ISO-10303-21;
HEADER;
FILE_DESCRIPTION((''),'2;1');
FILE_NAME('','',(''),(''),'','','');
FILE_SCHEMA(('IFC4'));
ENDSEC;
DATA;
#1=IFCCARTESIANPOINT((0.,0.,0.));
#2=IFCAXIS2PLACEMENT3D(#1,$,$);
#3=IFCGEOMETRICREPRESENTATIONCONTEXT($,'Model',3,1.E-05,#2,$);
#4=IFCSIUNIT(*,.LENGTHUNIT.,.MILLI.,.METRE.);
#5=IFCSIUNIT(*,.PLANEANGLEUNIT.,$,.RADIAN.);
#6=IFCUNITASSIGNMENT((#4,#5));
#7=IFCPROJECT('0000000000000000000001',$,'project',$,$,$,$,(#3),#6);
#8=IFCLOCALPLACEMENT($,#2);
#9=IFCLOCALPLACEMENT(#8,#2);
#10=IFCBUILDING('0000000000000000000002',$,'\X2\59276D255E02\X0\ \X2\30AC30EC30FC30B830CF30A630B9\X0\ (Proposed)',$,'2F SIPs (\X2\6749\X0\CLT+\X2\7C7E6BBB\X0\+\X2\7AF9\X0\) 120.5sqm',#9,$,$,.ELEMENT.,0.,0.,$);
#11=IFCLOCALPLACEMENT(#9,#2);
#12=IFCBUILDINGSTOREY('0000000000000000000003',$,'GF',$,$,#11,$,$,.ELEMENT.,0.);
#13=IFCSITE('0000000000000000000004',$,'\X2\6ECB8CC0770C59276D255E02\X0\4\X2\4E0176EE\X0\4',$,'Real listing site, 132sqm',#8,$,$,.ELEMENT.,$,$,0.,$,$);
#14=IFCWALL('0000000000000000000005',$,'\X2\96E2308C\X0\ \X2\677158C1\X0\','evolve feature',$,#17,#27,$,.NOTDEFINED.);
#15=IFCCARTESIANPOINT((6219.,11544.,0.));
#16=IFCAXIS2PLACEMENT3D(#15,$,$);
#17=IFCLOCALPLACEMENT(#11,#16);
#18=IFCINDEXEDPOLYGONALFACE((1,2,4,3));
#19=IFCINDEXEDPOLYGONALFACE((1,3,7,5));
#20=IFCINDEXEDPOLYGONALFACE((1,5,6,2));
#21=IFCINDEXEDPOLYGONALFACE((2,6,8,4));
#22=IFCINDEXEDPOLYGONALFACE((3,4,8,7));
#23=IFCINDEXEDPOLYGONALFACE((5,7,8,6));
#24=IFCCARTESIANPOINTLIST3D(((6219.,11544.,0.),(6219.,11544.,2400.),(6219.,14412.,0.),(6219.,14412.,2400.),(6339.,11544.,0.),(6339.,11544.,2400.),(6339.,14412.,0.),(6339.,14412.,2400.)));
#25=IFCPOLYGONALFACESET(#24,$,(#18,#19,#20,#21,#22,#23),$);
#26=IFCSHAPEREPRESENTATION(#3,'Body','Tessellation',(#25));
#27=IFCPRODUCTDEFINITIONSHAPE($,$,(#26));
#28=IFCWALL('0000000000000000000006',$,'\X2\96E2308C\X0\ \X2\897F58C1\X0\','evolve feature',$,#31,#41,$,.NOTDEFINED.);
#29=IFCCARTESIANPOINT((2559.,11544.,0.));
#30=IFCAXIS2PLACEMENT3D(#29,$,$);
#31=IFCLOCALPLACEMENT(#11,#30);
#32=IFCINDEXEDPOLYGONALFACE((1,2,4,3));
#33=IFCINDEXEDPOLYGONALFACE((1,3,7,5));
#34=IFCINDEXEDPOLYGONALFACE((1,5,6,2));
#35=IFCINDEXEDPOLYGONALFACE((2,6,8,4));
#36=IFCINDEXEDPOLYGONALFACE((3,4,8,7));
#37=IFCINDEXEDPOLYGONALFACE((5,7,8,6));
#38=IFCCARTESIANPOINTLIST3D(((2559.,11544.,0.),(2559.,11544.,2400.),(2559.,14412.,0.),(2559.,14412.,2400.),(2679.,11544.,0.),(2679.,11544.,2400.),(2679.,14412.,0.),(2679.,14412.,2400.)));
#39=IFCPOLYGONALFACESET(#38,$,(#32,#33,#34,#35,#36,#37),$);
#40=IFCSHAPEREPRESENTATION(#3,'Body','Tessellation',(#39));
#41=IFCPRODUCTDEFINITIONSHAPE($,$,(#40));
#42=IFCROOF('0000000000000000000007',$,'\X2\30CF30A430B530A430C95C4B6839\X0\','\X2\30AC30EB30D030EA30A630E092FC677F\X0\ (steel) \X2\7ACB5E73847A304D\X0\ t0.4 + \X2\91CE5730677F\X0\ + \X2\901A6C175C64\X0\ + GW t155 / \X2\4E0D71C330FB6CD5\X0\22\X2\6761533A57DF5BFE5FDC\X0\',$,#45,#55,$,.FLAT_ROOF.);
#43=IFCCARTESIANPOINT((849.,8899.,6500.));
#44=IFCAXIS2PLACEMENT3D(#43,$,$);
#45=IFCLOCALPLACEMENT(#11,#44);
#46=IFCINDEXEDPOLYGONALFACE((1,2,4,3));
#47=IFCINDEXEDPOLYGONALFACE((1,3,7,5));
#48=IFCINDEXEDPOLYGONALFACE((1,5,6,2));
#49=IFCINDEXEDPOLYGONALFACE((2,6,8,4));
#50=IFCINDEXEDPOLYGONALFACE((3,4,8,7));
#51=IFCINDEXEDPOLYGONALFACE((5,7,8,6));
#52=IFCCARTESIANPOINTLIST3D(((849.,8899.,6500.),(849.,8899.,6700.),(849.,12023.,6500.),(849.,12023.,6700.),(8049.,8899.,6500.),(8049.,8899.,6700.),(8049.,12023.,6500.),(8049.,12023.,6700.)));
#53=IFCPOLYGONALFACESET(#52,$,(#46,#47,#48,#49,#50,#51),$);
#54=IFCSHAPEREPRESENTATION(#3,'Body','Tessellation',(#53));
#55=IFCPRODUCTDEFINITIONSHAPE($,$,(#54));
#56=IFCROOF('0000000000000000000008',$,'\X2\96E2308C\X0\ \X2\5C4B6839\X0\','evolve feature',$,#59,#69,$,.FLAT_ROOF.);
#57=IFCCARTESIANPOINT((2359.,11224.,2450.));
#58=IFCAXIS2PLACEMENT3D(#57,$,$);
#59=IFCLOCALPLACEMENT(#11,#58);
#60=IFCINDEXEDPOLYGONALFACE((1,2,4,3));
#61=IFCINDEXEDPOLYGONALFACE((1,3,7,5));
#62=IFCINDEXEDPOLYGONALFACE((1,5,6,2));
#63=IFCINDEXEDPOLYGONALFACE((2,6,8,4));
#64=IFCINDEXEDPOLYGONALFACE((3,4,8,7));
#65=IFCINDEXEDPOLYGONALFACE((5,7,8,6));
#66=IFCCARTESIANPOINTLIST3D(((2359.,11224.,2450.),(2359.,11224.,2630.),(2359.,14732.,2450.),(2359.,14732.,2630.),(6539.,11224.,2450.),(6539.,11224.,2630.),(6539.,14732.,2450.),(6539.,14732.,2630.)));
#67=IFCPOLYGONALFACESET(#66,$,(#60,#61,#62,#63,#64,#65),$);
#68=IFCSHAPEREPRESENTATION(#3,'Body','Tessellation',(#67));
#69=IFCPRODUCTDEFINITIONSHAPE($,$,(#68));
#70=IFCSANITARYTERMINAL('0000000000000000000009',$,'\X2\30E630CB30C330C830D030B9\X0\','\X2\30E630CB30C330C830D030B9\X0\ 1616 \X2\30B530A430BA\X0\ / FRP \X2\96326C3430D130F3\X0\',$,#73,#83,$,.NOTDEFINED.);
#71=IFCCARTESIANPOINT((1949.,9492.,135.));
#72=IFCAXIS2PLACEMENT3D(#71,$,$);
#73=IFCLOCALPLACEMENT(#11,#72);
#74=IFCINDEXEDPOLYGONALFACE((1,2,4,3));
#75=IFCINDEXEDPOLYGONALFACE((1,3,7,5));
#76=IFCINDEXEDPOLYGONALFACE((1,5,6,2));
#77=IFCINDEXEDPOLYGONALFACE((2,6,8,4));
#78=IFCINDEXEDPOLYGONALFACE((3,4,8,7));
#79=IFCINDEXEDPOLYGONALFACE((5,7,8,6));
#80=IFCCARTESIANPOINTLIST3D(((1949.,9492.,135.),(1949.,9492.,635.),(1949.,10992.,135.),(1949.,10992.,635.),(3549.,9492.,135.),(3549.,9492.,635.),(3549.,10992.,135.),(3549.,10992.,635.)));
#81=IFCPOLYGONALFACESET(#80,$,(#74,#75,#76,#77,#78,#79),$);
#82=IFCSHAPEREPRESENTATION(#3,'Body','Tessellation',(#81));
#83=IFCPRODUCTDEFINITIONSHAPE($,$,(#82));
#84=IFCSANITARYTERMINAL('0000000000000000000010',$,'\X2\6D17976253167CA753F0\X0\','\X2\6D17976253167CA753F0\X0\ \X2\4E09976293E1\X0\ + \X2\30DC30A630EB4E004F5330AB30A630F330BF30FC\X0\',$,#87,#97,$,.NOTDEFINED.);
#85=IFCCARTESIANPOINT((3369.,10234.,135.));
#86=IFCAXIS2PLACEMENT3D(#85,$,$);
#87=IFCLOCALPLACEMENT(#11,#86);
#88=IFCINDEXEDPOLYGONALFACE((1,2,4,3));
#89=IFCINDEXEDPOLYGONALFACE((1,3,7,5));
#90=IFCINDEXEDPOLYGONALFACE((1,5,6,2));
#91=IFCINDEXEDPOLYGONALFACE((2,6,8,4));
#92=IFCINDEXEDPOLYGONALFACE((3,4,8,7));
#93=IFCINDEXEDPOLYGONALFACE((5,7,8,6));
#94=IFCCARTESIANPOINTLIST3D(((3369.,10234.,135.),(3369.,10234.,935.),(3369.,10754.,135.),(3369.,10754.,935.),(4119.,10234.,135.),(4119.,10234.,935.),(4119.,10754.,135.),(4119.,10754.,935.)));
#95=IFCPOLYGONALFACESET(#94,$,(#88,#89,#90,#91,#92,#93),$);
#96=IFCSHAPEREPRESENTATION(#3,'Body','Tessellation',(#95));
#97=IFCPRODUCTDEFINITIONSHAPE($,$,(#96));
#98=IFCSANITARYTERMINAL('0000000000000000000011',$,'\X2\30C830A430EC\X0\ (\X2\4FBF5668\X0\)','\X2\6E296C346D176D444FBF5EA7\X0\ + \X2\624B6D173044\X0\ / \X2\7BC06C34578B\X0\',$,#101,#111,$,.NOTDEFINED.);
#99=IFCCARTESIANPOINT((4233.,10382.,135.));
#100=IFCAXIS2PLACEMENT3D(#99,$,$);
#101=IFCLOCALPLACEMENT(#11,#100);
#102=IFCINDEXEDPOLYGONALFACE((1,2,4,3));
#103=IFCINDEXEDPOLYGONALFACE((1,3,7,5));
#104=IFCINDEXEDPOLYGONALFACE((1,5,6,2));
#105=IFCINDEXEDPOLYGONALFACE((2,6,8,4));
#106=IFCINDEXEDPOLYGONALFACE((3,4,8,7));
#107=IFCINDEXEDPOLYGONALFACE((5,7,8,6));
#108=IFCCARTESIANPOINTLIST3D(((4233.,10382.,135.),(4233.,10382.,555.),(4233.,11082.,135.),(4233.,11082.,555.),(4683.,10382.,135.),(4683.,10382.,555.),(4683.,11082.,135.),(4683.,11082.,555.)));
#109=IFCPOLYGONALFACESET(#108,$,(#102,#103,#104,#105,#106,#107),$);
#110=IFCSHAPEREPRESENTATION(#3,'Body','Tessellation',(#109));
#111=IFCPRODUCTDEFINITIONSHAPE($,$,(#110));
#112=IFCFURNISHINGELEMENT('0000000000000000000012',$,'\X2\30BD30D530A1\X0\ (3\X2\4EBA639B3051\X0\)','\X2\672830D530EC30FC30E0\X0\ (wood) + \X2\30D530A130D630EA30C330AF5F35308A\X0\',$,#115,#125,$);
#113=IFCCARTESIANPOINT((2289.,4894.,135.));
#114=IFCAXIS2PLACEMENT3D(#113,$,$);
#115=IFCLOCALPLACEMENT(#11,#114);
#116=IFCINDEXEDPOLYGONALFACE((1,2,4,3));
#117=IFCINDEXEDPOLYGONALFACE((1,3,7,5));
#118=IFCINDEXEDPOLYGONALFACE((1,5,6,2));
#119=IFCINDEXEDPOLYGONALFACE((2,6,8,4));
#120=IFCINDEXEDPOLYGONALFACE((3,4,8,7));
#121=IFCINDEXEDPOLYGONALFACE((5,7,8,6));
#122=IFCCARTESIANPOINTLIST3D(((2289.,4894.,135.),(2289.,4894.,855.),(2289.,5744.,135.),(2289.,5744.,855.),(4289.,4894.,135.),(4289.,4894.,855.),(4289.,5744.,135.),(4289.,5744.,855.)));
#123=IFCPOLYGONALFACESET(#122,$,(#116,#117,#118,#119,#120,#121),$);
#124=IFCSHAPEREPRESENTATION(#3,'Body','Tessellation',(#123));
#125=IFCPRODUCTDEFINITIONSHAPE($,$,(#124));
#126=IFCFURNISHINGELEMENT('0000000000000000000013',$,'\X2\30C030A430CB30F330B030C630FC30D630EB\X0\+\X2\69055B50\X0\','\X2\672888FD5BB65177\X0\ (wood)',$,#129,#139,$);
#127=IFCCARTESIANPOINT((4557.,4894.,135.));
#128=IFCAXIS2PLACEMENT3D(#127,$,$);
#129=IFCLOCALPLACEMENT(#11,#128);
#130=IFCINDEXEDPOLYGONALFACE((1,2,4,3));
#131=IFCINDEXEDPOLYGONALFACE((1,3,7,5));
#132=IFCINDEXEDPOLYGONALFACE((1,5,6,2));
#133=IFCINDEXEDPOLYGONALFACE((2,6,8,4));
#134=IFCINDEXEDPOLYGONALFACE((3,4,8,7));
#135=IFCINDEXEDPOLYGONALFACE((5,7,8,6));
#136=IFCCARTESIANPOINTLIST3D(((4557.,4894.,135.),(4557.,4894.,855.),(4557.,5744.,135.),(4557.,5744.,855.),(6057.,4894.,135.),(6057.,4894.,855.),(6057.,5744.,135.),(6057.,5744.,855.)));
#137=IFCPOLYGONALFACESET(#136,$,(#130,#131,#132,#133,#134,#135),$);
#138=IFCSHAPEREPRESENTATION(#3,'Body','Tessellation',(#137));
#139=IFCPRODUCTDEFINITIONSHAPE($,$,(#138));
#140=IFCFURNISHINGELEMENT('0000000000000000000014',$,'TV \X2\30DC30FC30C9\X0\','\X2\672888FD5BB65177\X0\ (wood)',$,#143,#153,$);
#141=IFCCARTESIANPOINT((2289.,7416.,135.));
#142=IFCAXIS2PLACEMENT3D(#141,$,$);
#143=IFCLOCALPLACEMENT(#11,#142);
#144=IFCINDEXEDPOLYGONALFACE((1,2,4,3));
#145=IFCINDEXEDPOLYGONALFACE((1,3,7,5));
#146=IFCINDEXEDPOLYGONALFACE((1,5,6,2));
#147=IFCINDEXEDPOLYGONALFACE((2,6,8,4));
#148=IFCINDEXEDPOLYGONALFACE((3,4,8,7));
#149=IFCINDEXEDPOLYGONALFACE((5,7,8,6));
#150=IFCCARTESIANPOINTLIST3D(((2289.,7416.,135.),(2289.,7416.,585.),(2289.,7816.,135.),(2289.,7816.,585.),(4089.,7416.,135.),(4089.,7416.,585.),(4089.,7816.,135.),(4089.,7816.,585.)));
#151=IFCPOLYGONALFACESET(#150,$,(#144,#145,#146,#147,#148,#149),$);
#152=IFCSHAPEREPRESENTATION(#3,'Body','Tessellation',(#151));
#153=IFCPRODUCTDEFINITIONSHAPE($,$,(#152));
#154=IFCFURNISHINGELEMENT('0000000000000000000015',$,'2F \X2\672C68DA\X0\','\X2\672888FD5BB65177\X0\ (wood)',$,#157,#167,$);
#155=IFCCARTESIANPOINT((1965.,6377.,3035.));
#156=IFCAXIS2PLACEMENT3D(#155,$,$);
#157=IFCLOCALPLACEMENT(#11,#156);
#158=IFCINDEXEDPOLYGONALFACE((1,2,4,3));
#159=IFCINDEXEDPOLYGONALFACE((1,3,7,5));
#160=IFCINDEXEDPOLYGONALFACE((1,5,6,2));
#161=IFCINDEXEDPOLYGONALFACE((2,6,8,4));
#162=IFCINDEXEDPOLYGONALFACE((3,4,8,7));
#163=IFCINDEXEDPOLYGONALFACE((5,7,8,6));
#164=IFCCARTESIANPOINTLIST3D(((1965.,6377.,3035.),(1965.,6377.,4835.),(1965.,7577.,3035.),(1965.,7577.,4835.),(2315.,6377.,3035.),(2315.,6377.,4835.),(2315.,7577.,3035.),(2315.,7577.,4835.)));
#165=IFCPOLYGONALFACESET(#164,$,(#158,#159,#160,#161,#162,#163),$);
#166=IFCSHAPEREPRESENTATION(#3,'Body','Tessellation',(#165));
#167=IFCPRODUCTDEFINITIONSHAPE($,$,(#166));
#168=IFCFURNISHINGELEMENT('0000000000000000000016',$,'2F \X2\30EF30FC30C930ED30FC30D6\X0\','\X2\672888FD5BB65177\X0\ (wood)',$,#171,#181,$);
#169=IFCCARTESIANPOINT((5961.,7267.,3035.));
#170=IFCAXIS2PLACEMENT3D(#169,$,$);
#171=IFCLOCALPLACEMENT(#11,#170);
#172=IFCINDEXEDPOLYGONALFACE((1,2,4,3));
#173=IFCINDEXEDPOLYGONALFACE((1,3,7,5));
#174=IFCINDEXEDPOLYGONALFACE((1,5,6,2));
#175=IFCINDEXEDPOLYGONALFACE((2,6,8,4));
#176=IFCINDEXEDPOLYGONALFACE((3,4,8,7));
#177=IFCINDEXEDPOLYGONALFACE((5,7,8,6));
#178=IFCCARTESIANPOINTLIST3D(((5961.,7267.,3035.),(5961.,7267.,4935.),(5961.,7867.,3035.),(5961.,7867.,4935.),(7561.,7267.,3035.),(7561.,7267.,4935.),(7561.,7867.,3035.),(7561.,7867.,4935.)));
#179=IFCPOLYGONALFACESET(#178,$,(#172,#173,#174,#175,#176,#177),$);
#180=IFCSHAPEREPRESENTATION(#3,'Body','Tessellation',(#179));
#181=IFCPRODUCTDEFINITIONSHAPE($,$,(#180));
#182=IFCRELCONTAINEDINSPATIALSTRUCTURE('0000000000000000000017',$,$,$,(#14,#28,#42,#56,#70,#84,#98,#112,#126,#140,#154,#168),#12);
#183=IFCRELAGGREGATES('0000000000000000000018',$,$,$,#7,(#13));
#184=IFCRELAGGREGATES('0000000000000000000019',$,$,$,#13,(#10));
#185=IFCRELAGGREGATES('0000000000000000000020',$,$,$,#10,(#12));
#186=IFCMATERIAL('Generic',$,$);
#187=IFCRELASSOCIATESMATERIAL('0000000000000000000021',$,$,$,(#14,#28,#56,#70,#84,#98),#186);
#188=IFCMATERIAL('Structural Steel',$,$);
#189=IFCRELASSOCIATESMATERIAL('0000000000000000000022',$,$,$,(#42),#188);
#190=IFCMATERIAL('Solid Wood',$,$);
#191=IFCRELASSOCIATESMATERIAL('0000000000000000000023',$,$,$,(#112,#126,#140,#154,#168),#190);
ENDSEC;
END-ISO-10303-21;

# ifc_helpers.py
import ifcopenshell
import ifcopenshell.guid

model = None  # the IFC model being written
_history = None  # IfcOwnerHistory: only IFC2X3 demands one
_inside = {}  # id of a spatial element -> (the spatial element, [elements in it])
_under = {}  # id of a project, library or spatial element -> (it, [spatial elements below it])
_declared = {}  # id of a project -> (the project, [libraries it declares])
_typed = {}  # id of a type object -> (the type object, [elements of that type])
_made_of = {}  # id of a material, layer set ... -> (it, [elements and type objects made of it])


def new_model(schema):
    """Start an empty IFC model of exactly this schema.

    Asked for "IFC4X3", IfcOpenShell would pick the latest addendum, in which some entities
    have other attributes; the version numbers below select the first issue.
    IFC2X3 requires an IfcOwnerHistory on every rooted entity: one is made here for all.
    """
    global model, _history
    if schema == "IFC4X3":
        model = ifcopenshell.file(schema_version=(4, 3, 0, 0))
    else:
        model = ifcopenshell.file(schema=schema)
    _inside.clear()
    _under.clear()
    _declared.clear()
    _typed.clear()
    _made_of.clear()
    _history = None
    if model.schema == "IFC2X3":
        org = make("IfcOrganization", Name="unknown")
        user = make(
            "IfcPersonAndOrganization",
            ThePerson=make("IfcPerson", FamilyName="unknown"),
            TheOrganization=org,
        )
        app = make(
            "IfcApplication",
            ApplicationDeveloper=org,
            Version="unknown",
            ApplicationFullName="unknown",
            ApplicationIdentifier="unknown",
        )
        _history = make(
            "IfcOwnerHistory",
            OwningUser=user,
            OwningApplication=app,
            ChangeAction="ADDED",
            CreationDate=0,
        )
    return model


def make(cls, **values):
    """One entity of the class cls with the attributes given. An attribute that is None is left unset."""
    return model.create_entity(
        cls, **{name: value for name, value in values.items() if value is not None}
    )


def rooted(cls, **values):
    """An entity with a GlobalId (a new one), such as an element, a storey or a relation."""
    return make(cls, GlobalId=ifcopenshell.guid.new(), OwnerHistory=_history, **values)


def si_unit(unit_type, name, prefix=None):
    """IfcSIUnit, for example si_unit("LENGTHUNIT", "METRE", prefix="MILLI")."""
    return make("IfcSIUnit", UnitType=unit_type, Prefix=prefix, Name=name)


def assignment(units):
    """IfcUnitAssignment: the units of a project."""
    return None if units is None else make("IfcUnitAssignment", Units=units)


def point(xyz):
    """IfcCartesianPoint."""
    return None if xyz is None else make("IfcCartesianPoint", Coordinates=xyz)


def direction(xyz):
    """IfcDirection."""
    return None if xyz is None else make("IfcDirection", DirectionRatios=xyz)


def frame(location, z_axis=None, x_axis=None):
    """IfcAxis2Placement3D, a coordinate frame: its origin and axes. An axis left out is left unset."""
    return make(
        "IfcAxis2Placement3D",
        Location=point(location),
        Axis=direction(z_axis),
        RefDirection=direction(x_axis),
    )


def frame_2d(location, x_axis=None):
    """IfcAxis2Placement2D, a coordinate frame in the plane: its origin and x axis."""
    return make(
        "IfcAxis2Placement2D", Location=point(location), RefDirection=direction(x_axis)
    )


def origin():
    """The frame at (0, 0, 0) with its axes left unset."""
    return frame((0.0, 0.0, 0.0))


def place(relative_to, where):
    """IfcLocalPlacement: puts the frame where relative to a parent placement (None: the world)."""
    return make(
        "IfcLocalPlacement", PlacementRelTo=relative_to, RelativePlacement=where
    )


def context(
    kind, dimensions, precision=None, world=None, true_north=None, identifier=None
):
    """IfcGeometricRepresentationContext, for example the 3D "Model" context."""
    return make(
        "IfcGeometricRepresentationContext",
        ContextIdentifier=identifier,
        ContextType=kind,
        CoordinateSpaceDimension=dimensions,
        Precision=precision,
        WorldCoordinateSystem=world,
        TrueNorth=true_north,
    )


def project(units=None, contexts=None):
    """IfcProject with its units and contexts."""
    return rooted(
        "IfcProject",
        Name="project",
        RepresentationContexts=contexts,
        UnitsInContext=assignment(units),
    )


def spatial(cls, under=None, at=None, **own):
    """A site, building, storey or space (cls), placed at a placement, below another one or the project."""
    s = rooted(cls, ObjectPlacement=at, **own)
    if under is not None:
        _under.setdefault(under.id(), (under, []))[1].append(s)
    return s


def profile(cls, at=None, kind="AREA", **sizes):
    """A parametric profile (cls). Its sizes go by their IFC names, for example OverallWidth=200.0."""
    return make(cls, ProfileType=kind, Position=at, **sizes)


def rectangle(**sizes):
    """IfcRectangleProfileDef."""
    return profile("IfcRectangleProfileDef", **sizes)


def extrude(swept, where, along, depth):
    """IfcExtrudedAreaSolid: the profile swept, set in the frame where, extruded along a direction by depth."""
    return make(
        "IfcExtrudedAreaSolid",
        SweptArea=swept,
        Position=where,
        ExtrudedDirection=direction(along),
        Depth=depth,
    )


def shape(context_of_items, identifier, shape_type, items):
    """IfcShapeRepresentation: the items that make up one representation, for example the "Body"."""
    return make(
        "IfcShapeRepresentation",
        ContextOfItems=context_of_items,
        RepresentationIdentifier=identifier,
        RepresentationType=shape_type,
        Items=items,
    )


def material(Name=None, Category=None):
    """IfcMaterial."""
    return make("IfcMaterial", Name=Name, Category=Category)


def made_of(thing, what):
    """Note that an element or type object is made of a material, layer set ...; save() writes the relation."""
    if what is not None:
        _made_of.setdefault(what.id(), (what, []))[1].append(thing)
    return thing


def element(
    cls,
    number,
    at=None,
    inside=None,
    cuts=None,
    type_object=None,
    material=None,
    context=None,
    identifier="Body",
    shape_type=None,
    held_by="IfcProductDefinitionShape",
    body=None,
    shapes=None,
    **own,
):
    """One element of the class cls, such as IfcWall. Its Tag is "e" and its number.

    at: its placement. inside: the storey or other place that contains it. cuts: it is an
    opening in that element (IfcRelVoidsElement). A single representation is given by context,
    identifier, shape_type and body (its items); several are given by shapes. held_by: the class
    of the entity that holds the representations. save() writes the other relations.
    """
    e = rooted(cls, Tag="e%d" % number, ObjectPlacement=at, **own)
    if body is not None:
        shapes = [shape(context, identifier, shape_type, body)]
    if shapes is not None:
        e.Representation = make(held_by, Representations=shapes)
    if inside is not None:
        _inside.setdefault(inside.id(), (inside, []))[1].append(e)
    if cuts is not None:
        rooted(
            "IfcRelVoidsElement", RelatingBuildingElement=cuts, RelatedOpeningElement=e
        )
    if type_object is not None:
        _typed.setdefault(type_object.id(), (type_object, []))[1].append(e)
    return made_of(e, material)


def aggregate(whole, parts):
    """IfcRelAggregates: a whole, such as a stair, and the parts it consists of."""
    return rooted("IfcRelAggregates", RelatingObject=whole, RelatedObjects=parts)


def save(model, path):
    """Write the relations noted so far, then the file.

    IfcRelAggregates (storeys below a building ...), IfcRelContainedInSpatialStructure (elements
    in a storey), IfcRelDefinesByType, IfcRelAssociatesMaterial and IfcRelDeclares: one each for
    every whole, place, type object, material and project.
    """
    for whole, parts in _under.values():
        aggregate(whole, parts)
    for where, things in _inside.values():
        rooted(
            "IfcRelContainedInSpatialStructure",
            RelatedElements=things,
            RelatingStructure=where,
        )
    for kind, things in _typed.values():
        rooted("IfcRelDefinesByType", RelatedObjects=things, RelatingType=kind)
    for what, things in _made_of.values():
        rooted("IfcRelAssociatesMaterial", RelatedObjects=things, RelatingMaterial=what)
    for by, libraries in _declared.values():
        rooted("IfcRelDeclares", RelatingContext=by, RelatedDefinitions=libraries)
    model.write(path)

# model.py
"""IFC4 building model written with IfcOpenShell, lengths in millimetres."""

from ifc_helpers import new_model, si_unit, frame, frame_2d, origin, place, context, project, spatial, rectangle, extrude, material, element, save


model = new_model("IFC4")

# Units and contexts
model_context = context("Model", 3, precision=1e-05, world=origin())
ifc_project = project(units=[si_unit("LENGTHUNIT", "METRE", prefix="MILLI"), si_unit("PLANEANGLEUNIT", "RADIAN")], contexts=[model_context])

# Site, building, storey
site_placement = place(None, origin())
site = spatial("IfcSite", under=ifc_project, at=site_placement, Name="滋賀県大津市4丁目4", ObjectType="Real listing site, 132sqm", CompositionType="ELEMENT", RefElevation=0.0)
building_placement = place(site_placement, origin())
building = spatial("IfcBuilding", under=site, at=building_placement, Name="大津市 ガレージハウス (Proposed)", ObjectType="2F SIPs (杉CLT+籾殻+竹) 120.5sqm", CompositionType="ELEMENT", ElevationOfRefHeight=0.0, ElevationOfTerrain=0.0)
storey_placement = place(building_placement, origin())
storey = spatial("IfcBuildingStorey", under=building, at=storey_placement, Name="GF", CompositionType="ELEMENT", Elevation=0.0)

# Shared definitions
ifc_material_1 = material(Name="Generic")

# Shared definitions
ifc_material_2 = material(Name="Solid Wood")

# Walls
wall_1_placement = place(storey_placement, frame((6219.0, 11544.0, 0.0)))
element("IfcWall", 1, at=wall_1_placement, inside=storey, material=ifc_material_1, Name="離れ 東壁", Description="evolve feature", PredefinedType="NOTDEFINED", context=model_context, shape_type="SweptSolid", body=[
    extrude(rectangle(XDim=120.0, YDim=2868.0, at=frame_2d((60.0, 1434.0))), frame((6219.0, 11544.0, 0.0)), (0.0, 0.0, 1.0), 2400.0),
])
wall_2_placement = place(storey_placement, frame((2559.0, 11544.0, 0.0)))
element("IfcWall", 2, at=wall_2_placement, inside=storey, material=ifc_material_1, Name="離れ 西壁", Description="evolve feature", PredefinedType="NOTDEFINED", context=model_context, shape_type="SweptSolid", body=[
    extrude(rectangle(XDim=120.0, YDim=2868.0, at=frame_2d((60.0, 1434.0))), frame((2559.0, 11544.0, 0.0)), (0.0, 0.0, 1.0), 2400.0),
])

# Roofs
ifc_material_3 = material(Name="Structural Steel")
roof_1_placement = place(storey_placement, frame((849.0, 8899.0, 6500.0)))
element("IfcRoof", 3, at=roof_1_placement, inside=storey, material=ifc_material_3, Name="ハイサイド屋根", Description="ガルバリウム鋼板 (steel) 立平葺き t0.4 + 野地板 + 通気層 + GW t155 / 不燃・法22条区域対応", PredefinedType="FLAT_ROOF", context=model_context, shape_type="SweptSolid", body=[
    extrude(rectangle(XDim=7200.0, YDim=3124.0, at=frame_2d((3600.0, 1562.0))), frame((849.0, 8899.0, 6500.0)), (0.0, 0.0, 1.0), 200.0),
])
roof_2_placement = place(storey_placement, frame((2359.0, 11224.0, 2450.0)))
element("IfcRoof", 4, at=roof_2_placement, inside=storey, material=ifc_material_1, Name="離れ 屋根", Description="evolve feature", PredefinedType="FLAT_ROOF", context=model_context, shape_type="SweptSolid", body=[
    extrude(rectangle(XDim=4180.0, YDim=3508.0, at=frame_2d((2090.0, 1754.0))), frame((2359.0, 11224.0, 2450.0)), (0.0, 0.0, 1.0), 180.0),
])

# Sanitary terminals
sanitary_terminal_1_placement = place(storey_placement, frame((1949.0, 9492.0, 135.0)))
element("IfcSanitaryTerminal", 5, at=sanitary_terminal_1_placement, inside=storey, material=ifc_material_1, Name="ユニットバス", Description="ユニットバス 1616 サイズ / FRP 防水パン", PredefinedType="NOTDEFINED", context=model_context, shape_type="SweptSolid", body=[
    extrude(rectangle(XDim=1600.0, YDim=1500.0, at=frame_2d((800.0, 750.0))), frame((1949.0, 9492.0, 135.0)), (0.0, 0.0, 1.0), 500.0),
])
sanitary_terminal_2_placement = place(storey_placement, frame((3369.0, 10234.0, 135.0)))
element("IfcSanitaryTerminal", 6, at=sanitary_terminal_2_placement, inside=storey, material=ifc_material_1, Name="洗面化粧台", Description="洗面化粧台 三面鏡 + ボウル一体カウンター", PredefinedType="NOTDEFINED", context=model_context, shape_type="SweptSolid", body=[
    extrude(rectangle(XDim=750.0, YDim=520.0, at=frame_2d((375.0, 260.0))), frame((3369.0, 10234.0, 135.0)), (0.0, 0.0, 1.0), 800.0),
])
sanitary_terminal_3_placement = place(storey_placement, frame((4233.0, 10382.0, 135.0)))
element("IfcSanitaryTerminal", 7, at=sanitary_terminal_3_placement, inside=storey, material=ifc_material_1, Name="トイレ (便器)", Description="温水洗浄便座 + 手洗い / 節水型", PredefinedType="NOTDEFINED", context=model_context, shape_type="SweptSolid", body=[
    extrude(rectangle(XDim=450.0, YDim=700.0, at=frame_2d((225.0, 350.0))), frame((4233.0, 10382.0, 135.0)), (0.0, 0.0, 1.0), 420.0),
])

# Furnishing elements
furnishing_1_placement = place(storey_placement, frame((2289.0, 4894.0, 135.0)))
element("IfcFurnishingElement", 8, at=furnishing_1_placement, inside=storey, material=ifc_material_2, Name="ソファ (3人掛け)", Description="木フレーム (wood) + ファブリック張り", context=model_context, shape_type="SweptSolid", body=[
    extrude(rectangle(XDim=2000.0, YDim=850.0, at=frame_2d((1000.0, 425.0))), frame((2289.0, 4894.0, 135.0)), (0.0, 0.0, 1.0), 720.0),
])
furnishing_2_placement = place(storey_placement, frame((4557.0, 4894.0, 135.0)))
element("IfcFurnishingElement", 9, at=furnishing_2_placement, inside=storey, material=ifc_material_2, Name="ダイニングテーブル+椅子", Description="木製家具 (wood)", context=model_context, shape_type="SweptSolid", body=[
    extrude(rectangle(XDim=1500.0, YDim=850.0, at=frame_2d((750.0, 425.0))), frame((4557.0, 4894.0, 135.0)), (0.0, 0.0, 1.0), 720.0),
])
furnishing_3_placement = place(storey_placement, frame((2289.0, 7416.0, 135.0)))
element("IfcFurnishingElement", 10, at=furnishing_3_placement, inside=storey, material=ifc_material_2, Name="TV ボード", Description="木製家具 (wood)", context=model_context, shape_type="SweptSolid", body=[
    extrude(rectangle(XDim=1800.0, YDim=400.0, at=frame_2d((900.0, 200.0))), frame((2289.0, 7416.0, 135.0)), (0.0, 0.0, 1.0), 450.0),
])
furnishing_4_placement = place(storey_placement, frame((1965.0, 6377.0, 3035.0)))
element("IfcFurnishingElement", 11, at=furnishing_4_placement, inside=storey, material=ifc_material_2, Name="2F 本棚", Description="木製家具 (wood)", context=model_context, shape_type="SweptSolid", body=[
    extrude(rectangle(XDim=350.0, YDim=1200.0, at=frame_2d((175.0, 600.0))), frame((1965.0, 6377.0, 3035.0)), (0.0, 0.0, 1.0), 1800.0),
])
furnishing_5_placement = place(storey_placement, frame((5961.0, 7267.0, 3035.0)))
element("IfcFurnishingElement", 12, at=furnishing_5_placement, inside=storey, material=ifc_material_2, Name="2F ワードローブ", Description="木製家具 (wood)", context=model_context, shape_type="SweptSolid", body=[
    extrude(rectangle(XDim=1600.0, YDim=600.0, at=frame_2d((800.0, 300.0))), frame((5961.0, 7267.0, 3035.0)), (0.0, 0.0, 1.0), 1900.0),
])

save(model, "model.ifc")
